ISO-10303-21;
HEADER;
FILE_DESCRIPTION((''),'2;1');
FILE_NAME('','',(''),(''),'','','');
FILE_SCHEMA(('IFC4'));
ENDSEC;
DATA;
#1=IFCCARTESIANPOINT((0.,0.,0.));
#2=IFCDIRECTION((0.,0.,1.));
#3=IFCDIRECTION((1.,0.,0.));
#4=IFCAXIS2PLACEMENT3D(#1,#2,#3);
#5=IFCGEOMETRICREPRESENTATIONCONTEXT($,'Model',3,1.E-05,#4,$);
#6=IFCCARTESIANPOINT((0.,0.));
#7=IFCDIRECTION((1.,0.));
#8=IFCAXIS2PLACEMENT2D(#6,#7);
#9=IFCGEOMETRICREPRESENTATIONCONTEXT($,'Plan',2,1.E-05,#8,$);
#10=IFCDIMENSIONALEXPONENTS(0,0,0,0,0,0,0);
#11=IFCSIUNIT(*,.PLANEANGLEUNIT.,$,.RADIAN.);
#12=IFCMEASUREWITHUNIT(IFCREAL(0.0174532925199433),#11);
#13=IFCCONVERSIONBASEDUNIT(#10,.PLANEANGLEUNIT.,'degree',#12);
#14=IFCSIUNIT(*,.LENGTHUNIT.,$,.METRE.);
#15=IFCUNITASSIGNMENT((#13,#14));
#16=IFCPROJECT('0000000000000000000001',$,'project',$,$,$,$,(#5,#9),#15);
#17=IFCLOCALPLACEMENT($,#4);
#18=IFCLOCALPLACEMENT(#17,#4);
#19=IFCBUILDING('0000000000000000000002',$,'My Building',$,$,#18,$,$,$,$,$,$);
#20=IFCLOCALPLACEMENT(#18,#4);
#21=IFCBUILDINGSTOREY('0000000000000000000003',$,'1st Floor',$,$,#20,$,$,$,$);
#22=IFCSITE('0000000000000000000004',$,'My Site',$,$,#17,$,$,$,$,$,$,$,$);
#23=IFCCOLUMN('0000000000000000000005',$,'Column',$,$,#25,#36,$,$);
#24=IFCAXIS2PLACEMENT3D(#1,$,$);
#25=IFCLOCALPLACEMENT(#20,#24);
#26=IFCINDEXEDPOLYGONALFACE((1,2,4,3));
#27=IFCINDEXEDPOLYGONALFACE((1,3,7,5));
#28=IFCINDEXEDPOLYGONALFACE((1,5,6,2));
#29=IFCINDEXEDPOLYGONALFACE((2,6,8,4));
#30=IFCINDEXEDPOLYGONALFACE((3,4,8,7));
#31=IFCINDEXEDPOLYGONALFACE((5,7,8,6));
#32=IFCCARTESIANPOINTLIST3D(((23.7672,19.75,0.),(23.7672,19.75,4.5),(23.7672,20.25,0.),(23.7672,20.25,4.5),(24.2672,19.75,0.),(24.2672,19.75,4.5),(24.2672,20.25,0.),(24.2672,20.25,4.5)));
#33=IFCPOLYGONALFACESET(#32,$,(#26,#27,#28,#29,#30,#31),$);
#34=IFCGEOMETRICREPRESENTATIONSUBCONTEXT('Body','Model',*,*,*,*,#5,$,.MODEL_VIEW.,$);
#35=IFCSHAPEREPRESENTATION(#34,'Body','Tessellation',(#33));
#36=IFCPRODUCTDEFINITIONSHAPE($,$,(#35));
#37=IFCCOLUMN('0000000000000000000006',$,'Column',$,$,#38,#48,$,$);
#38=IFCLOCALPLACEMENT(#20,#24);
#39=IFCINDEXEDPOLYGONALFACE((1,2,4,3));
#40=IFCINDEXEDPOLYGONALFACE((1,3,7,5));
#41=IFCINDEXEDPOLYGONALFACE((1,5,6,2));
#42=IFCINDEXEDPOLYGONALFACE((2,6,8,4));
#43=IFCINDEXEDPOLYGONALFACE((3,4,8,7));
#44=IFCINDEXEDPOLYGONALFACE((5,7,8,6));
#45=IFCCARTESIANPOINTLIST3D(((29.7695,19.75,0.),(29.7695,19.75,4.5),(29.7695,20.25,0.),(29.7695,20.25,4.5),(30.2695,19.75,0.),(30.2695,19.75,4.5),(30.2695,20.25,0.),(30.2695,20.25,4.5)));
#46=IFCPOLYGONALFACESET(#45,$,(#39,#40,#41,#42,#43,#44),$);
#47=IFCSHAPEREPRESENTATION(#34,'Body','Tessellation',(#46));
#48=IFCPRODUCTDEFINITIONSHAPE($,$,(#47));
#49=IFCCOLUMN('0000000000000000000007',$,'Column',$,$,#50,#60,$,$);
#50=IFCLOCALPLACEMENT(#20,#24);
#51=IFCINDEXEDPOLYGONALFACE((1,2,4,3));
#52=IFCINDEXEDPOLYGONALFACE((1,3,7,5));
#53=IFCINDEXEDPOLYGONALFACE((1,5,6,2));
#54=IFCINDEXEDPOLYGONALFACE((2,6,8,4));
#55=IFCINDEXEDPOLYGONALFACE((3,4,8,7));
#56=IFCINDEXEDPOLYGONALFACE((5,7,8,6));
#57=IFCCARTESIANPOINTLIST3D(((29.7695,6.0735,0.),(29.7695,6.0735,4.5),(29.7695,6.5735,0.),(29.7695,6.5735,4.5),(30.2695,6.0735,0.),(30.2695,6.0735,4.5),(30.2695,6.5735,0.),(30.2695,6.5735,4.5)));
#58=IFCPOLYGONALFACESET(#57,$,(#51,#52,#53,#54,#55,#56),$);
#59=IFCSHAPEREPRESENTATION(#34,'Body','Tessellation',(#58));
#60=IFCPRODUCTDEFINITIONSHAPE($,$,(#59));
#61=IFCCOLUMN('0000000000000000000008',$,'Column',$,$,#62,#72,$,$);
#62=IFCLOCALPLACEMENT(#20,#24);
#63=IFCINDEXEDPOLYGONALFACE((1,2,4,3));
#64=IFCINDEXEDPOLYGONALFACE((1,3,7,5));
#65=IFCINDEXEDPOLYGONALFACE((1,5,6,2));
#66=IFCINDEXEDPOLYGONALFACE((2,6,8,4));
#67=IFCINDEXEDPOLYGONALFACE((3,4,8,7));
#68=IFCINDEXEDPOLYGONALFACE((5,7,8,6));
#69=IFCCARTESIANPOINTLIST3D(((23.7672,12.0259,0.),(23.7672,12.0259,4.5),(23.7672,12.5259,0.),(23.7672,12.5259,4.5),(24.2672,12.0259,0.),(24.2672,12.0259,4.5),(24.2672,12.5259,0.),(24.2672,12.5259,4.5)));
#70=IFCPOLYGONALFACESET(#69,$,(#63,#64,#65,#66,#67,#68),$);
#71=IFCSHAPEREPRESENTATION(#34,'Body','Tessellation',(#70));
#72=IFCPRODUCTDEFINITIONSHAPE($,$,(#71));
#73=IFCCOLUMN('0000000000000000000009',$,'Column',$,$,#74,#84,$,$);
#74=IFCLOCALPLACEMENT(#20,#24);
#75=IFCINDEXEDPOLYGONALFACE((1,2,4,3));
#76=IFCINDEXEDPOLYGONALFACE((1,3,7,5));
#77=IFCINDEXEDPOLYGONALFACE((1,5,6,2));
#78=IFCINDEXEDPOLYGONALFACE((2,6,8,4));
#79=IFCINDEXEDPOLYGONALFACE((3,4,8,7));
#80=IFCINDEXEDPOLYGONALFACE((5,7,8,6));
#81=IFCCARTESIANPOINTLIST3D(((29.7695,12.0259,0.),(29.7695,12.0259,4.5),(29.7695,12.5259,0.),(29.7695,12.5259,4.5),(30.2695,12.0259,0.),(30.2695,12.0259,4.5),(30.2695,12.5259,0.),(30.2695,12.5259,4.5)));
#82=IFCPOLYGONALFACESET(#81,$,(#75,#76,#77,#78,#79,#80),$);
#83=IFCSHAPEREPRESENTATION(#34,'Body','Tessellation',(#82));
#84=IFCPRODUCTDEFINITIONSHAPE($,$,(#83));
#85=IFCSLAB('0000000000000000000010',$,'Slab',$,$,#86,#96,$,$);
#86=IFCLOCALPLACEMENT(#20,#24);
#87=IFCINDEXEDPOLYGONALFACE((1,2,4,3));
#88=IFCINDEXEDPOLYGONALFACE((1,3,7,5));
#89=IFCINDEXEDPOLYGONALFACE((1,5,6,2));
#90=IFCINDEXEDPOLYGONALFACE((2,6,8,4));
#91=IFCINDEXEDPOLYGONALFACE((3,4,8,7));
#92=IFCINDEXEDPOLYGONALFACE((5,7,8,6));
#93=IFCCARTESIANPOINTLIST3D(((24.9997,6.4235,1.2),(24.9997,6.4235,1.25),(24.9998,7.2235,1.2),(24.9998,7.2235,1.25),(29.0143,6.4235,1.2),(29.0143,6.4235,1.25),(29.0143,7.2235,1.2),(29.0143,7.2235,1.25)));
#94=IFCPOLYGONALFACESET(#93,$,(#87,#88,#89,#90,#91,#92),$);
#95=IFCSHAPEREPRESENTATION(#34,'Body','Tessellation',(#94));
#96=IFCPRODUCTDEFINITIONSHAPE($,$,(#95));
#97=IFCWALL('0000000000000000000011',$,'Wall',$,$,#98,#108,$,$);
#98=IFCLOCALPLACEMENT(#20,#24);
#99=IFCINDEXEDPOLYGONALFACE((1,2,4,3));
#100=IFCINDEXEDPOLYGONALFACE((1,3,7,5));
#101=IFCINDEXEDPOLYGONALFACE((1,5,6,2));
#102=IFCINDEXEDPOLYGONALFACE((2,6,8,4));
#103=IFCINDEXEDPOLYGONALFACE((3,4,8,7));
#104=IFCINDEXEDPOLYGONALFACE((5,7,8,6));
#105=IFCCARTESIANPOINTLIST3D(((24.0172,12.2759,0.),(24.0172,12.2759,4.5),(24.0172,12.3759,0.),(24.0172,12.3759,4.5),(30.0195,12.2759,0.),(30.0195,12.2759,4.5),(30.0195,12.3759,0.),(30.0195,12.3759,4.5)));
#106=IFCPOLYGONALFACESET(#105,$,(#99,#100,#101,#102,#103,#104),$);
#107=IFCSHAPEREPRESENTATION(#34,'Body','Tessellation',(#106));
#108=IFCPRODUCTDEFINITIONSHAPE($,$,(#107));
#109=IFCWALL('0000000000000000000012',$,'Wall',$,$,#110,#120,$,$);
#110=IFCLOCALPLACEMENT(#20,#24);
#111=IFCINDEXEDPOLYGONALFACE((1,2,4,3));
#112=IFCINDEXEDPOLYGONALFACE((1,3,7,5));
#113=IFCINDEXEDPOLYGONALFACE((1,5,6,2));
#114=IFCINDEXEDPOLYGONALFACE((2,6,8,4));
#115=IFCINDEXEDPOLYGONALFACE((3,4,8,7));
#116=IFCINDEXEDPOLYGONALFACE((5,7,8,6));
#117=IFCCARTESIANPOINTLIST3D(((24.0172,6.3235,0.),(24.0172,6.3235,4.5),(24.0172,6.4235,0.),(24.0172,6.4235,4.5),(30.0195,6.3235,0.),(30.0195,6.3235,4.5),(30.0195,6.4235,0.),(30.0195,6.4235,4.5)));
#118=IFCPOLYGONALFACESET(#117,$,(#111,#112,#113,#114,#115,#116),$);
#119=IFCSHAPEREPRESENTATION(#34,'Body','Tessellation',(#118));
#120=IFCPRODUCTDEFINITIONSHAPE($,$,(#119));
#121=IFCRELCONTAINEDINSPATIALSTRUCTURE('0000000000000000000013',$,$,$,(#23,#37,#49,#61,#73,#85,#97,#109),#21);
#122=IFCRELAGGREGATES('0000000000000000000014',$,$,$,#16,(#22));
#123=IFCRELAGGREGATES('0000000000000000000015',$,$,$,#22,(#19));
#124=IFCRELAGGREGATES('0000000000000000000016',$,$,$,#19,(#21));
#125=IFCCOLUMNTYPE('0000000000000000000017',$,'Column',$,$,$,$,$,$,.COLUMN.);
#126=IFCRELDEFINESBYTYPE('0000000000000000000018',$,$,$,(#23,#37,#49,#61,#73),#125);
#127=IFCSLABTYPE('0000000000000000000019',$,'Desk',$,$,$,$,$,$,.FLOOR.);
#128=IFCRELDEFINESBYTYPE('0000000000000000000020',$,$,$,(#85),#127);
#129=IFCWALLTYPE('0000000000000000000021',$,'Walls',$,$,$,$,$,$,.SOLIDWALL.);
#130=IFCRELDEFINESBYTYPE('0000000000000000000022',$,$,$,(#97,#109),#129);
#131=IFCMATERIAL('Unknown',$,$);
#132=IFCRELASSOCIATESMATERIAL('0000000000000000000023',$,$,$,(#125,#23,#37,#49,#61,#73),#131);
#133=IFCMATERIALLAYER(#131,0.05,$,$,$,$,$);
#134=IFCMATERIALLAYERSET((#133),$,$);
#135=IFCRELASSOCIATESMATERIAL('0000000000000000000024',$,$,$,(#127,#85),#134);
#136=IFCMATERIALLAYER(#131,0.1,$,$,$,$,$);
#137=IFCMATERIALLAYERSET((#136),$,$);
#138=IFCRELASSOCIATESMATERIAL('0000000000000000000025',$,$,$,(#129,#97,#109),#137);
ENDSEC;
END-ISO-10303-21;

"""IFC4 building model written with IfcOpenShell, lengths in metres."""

from ifc_helpers import new_model, entity, si_unit, converted_unit, frame, origin_with_axes, origin_2d_with_axis, place, context, subcontext, project, spatial, line, indexed_curve, rectangle, outline, extrude, material, layer, layer_set, layer_usage, material_profile, profile_set, profile_usage, type_object, element, save


model = new_model("IFC4")

# Units and contexts
model_context = context("Model", 3, precision=1e-05, world=origin_with_axes())
plan_context = context("Plan", 2, precision=1e-05, world=origin_2d_with_axis())
body_context_1 = subcontext(model_context, "Body", "Model", "MODEL_VIEW")
ifc_project = project(units=[converted_unit("PLANEANGLEUNIT", "degree", entity("IfcReal", 0.0174532925199433), si_unit("PLANEANGLEUNIT", "RADIAN"), dimensions=[0, 0, 0, 0, 0, 0, 0]), si_unit("LENGTHUNIT", "METRE")], contexts=[model_context, plan_context])

# Site, building, storey
site_placement = place(None, origin_with_axes())
site = spatial("IfcSite", under=ifc_project, at=site_placement, Name="My Site")
building_placement = place(site_placement, origin_with_axes())
building = spatial("IfcBuilding", under=site, at=building_placement, Name="My Building")
storey_placement = place(building_placement, origin_with_axes())
storey = spatial("IfcBuildingStorey", under=building, at=storey_placement, Name="1st Floor")

# Columns
ifc_material = material(Name="Unknown")
ifc_material_profile = material_profile(ifc_material, rectangle(XDim=0.5, YDim=0.5))
ifc_profile_set = profile_set([ifc_material_profile])
ifc_profile_usage_1 = profile_usage(ifc_profile_set, cardinal=5)
column_type = type_object("IfcColumnType", Name="Column", PredefinedType="COLUMN", material=ifc_profile_set)
column_1_placement = place(storey_placement, frame((24.0172, 20.0, 0.0), z_axis=(0.0, 0.0, 1.0), x_axis=(1.0, 0.0, 0.0)))
element("IfcColumn", 1, at=column_1_placement, inside=storey, type_object=column_type, material=ifc_profile_usage_1, Name="Column", context=body_context_1, shape_type="SweptSolid", body=[
    extrude(rectangle(XDim=0.5, YDim=0.5), origin_with_axes(), (0.0, 0.0, 1.0), 4.5),
])
ifc_profile_usage_2 = profile_usage(ifc_profile_set, cardinal=5)
column_2_placement = place(storey_placement, frame((30.0195, 20.0, 0.0), z_axis=(0.0, 0.0, 1.0), x_axis=(1.0, 0.0, 0.0)))
element("IfcColumn", 2, at=column_2_placement, inside=storey, type_object=column_type, material=ifc_profile_usage_2, Name="Column", context=body_context_1, shape_type="SweptSolid", body=[
    extrude(rectangle(XDim=0.5, YDim=0.5), origin_with_axes(), (0.0, 0.0, 1.0), 4.5),
])
ifc_profile_usage_3 = profile_usage(ifc_profile_set, cardinal=5)
column_3_placement = place(storey_placement, frame((30.0195, 6.3235, 0.0), z_axis=(0.0, 0.0, 1.0), x_axis=(1.0, 0.0, 0.0)))
element("IfcColumn", 3, at=column_3_placement, inside=storey, type_object=column_type, material=ifc_profile_usage_3, Name="Column", context=body_context_1, shape_type="SweptSolid", body=[
    extrude(rectangle(XDim=0.5, YDim=0.5), origin_with_axes(), (0.0, 0.0, 1.0), 4.5),
])
ifc_profile_usage_4 = profile_usage(ifc_profile_set, cardinal=5)
column_4_placement = place(storey_placement, frame((24.0172, 12.2759, 0.0), z_axis=(0.0, 0.0, 1.0), x_axis=(1.0, 0.0, 0.0)))
element("IfcColumn", 4, at=column_4_placement, inside=storey, type_object=column_type, material=ifc_profile_usage_4, Name="Column", context=body_context_1, shape_type="SweptSolid", body=[
    extrude(rectangle(XDim=0.5, YDim=0.5), origin_with_axes(), (0.0, 0.0, 1.0), 4.5),
])
ifc_profile_usage_5 = profile_usage(ifc_profile_set, cardinal=5)
column_5_placement = place(storey_placement, frame((30.0195, 12.2759, 0.0), z_axis=(0.0, 0.0, 1.0), x_axis=(1.0, 0.0, 0.0)))
element("IfcColumn", 5, at=column_5_placement, inside=storey, type_object=column_type, material=ifc_profile_usage_5, Name="Column", context=body_context_1, shape_type="SweptSolid", body=[
    extrude(rectangle(XDim=0.5, YDim=0.5), origin_with_axes(), (0.0, 0.0, 1.0), 4.5),
])

# Slab
ifc_layer_1 = layer(ifc_material, 0.05)
ifc_layer_set_1 = layer_set([ifc_layer_1])
ifc_layer_usage_1 = layer_usage(ifc_layer_set_1, "AXIS3", "POSITIVE", -0.05)
slab_type = type_object("IfcSlabType", Name="Desk", PredefinedType="FLOOR", material=ifc_layer_set_1)
slab_placement = place(storey_placement, frame((24.9997, 6.4235, 1.25), z_axis=(0.0, 0.0, 1.0), x_axis=(1.0, 0.0, 0.0)))
element("IfcSlab", 6, at=slab_placement, inside=storey, type_object=slab_type, material=ifc_layer_usage_1, Name="Slab", context=body_context_1, shape_type="SweptSolid", body=[
    extrude(outline(indexed_curve([(0.0, 0.0), (4.0146, 0.0), (4.0146, 0.8), (0.0, 0.8), (0.0, 0.0)])), frame((0.0, 0.0, -0.05), z_axis=(0.0, 0.0, 1.0), x_axis=(1.0, 0.0, 0.0)), (0.0, 0.0, 1.0), 0.05),
])

# Shared definitions
ifc_layer_2 = layer(ifc_material, 0.1)
ifc_layer_set_2 = layer_set([ifc_layer_2])
wall_type = type_object("IfcWallType", Name="Walls", PredefinedType="SOLIDWALL", material=ifc_layer_set_2)

# Walls
ifc_layer_usage_2 = layer_usage(ifc_layer_set_2, "AXIS2", "POSITIVE", 0.0)
wall_1_placement = place(storey_placement, frame((24.0172, 12.2759, 0.0), z_axis=(0.0, 0.0, 1.0), x_axis=(1.0, 0.0, 0.0)))
element("IfcWall", 7, at=wall_1_placement, inside=storey, type_object=wall_type, material=ifc_layer_usage_2, Name="Wall", context=body_context_1, shape_type="SweptSolid", body=[
    extrude(outline(indexed_curve([(0.0, 0.0), (0.0, 0.1), (6.0024, 0.1), (6.0024, 0.0)], segments=[line(1, 2, 3, 4, 1)])), origin_with_axes(), (0.0, 0.0, 1.0), 4.5),
])
ifc_layer_usage_3 = layer_usage(ifc_layer_set_2, "AXIS2", "POSITIVE", 0.0)
wall_2_placement = place(storey_placement, frame((24.0172, 6.3235, 0.0), z_axis=(0.0, 0.0, 1.0), x_axis=(1.0, 0.0, 0.0)))
element("IfcWall", 8, at=wall_2_placement, inside=storey, type_object=wall_type, material=ifc_layer_usage_3, Name="Wall", context=body_context_1, shape_type="SweptSolid", body=[
    extrude(outline(indexed_curve([(0.0, 0.0), (0.0, 0.1), (6.0023, 0.1), (6.0023, 0.0)], segments=[line(1, 2, 3, 4, 1)])), origin_with_axes(), (0.0, 0.0, 1.0), 4.5),
])

save(model, "model.ifc")
